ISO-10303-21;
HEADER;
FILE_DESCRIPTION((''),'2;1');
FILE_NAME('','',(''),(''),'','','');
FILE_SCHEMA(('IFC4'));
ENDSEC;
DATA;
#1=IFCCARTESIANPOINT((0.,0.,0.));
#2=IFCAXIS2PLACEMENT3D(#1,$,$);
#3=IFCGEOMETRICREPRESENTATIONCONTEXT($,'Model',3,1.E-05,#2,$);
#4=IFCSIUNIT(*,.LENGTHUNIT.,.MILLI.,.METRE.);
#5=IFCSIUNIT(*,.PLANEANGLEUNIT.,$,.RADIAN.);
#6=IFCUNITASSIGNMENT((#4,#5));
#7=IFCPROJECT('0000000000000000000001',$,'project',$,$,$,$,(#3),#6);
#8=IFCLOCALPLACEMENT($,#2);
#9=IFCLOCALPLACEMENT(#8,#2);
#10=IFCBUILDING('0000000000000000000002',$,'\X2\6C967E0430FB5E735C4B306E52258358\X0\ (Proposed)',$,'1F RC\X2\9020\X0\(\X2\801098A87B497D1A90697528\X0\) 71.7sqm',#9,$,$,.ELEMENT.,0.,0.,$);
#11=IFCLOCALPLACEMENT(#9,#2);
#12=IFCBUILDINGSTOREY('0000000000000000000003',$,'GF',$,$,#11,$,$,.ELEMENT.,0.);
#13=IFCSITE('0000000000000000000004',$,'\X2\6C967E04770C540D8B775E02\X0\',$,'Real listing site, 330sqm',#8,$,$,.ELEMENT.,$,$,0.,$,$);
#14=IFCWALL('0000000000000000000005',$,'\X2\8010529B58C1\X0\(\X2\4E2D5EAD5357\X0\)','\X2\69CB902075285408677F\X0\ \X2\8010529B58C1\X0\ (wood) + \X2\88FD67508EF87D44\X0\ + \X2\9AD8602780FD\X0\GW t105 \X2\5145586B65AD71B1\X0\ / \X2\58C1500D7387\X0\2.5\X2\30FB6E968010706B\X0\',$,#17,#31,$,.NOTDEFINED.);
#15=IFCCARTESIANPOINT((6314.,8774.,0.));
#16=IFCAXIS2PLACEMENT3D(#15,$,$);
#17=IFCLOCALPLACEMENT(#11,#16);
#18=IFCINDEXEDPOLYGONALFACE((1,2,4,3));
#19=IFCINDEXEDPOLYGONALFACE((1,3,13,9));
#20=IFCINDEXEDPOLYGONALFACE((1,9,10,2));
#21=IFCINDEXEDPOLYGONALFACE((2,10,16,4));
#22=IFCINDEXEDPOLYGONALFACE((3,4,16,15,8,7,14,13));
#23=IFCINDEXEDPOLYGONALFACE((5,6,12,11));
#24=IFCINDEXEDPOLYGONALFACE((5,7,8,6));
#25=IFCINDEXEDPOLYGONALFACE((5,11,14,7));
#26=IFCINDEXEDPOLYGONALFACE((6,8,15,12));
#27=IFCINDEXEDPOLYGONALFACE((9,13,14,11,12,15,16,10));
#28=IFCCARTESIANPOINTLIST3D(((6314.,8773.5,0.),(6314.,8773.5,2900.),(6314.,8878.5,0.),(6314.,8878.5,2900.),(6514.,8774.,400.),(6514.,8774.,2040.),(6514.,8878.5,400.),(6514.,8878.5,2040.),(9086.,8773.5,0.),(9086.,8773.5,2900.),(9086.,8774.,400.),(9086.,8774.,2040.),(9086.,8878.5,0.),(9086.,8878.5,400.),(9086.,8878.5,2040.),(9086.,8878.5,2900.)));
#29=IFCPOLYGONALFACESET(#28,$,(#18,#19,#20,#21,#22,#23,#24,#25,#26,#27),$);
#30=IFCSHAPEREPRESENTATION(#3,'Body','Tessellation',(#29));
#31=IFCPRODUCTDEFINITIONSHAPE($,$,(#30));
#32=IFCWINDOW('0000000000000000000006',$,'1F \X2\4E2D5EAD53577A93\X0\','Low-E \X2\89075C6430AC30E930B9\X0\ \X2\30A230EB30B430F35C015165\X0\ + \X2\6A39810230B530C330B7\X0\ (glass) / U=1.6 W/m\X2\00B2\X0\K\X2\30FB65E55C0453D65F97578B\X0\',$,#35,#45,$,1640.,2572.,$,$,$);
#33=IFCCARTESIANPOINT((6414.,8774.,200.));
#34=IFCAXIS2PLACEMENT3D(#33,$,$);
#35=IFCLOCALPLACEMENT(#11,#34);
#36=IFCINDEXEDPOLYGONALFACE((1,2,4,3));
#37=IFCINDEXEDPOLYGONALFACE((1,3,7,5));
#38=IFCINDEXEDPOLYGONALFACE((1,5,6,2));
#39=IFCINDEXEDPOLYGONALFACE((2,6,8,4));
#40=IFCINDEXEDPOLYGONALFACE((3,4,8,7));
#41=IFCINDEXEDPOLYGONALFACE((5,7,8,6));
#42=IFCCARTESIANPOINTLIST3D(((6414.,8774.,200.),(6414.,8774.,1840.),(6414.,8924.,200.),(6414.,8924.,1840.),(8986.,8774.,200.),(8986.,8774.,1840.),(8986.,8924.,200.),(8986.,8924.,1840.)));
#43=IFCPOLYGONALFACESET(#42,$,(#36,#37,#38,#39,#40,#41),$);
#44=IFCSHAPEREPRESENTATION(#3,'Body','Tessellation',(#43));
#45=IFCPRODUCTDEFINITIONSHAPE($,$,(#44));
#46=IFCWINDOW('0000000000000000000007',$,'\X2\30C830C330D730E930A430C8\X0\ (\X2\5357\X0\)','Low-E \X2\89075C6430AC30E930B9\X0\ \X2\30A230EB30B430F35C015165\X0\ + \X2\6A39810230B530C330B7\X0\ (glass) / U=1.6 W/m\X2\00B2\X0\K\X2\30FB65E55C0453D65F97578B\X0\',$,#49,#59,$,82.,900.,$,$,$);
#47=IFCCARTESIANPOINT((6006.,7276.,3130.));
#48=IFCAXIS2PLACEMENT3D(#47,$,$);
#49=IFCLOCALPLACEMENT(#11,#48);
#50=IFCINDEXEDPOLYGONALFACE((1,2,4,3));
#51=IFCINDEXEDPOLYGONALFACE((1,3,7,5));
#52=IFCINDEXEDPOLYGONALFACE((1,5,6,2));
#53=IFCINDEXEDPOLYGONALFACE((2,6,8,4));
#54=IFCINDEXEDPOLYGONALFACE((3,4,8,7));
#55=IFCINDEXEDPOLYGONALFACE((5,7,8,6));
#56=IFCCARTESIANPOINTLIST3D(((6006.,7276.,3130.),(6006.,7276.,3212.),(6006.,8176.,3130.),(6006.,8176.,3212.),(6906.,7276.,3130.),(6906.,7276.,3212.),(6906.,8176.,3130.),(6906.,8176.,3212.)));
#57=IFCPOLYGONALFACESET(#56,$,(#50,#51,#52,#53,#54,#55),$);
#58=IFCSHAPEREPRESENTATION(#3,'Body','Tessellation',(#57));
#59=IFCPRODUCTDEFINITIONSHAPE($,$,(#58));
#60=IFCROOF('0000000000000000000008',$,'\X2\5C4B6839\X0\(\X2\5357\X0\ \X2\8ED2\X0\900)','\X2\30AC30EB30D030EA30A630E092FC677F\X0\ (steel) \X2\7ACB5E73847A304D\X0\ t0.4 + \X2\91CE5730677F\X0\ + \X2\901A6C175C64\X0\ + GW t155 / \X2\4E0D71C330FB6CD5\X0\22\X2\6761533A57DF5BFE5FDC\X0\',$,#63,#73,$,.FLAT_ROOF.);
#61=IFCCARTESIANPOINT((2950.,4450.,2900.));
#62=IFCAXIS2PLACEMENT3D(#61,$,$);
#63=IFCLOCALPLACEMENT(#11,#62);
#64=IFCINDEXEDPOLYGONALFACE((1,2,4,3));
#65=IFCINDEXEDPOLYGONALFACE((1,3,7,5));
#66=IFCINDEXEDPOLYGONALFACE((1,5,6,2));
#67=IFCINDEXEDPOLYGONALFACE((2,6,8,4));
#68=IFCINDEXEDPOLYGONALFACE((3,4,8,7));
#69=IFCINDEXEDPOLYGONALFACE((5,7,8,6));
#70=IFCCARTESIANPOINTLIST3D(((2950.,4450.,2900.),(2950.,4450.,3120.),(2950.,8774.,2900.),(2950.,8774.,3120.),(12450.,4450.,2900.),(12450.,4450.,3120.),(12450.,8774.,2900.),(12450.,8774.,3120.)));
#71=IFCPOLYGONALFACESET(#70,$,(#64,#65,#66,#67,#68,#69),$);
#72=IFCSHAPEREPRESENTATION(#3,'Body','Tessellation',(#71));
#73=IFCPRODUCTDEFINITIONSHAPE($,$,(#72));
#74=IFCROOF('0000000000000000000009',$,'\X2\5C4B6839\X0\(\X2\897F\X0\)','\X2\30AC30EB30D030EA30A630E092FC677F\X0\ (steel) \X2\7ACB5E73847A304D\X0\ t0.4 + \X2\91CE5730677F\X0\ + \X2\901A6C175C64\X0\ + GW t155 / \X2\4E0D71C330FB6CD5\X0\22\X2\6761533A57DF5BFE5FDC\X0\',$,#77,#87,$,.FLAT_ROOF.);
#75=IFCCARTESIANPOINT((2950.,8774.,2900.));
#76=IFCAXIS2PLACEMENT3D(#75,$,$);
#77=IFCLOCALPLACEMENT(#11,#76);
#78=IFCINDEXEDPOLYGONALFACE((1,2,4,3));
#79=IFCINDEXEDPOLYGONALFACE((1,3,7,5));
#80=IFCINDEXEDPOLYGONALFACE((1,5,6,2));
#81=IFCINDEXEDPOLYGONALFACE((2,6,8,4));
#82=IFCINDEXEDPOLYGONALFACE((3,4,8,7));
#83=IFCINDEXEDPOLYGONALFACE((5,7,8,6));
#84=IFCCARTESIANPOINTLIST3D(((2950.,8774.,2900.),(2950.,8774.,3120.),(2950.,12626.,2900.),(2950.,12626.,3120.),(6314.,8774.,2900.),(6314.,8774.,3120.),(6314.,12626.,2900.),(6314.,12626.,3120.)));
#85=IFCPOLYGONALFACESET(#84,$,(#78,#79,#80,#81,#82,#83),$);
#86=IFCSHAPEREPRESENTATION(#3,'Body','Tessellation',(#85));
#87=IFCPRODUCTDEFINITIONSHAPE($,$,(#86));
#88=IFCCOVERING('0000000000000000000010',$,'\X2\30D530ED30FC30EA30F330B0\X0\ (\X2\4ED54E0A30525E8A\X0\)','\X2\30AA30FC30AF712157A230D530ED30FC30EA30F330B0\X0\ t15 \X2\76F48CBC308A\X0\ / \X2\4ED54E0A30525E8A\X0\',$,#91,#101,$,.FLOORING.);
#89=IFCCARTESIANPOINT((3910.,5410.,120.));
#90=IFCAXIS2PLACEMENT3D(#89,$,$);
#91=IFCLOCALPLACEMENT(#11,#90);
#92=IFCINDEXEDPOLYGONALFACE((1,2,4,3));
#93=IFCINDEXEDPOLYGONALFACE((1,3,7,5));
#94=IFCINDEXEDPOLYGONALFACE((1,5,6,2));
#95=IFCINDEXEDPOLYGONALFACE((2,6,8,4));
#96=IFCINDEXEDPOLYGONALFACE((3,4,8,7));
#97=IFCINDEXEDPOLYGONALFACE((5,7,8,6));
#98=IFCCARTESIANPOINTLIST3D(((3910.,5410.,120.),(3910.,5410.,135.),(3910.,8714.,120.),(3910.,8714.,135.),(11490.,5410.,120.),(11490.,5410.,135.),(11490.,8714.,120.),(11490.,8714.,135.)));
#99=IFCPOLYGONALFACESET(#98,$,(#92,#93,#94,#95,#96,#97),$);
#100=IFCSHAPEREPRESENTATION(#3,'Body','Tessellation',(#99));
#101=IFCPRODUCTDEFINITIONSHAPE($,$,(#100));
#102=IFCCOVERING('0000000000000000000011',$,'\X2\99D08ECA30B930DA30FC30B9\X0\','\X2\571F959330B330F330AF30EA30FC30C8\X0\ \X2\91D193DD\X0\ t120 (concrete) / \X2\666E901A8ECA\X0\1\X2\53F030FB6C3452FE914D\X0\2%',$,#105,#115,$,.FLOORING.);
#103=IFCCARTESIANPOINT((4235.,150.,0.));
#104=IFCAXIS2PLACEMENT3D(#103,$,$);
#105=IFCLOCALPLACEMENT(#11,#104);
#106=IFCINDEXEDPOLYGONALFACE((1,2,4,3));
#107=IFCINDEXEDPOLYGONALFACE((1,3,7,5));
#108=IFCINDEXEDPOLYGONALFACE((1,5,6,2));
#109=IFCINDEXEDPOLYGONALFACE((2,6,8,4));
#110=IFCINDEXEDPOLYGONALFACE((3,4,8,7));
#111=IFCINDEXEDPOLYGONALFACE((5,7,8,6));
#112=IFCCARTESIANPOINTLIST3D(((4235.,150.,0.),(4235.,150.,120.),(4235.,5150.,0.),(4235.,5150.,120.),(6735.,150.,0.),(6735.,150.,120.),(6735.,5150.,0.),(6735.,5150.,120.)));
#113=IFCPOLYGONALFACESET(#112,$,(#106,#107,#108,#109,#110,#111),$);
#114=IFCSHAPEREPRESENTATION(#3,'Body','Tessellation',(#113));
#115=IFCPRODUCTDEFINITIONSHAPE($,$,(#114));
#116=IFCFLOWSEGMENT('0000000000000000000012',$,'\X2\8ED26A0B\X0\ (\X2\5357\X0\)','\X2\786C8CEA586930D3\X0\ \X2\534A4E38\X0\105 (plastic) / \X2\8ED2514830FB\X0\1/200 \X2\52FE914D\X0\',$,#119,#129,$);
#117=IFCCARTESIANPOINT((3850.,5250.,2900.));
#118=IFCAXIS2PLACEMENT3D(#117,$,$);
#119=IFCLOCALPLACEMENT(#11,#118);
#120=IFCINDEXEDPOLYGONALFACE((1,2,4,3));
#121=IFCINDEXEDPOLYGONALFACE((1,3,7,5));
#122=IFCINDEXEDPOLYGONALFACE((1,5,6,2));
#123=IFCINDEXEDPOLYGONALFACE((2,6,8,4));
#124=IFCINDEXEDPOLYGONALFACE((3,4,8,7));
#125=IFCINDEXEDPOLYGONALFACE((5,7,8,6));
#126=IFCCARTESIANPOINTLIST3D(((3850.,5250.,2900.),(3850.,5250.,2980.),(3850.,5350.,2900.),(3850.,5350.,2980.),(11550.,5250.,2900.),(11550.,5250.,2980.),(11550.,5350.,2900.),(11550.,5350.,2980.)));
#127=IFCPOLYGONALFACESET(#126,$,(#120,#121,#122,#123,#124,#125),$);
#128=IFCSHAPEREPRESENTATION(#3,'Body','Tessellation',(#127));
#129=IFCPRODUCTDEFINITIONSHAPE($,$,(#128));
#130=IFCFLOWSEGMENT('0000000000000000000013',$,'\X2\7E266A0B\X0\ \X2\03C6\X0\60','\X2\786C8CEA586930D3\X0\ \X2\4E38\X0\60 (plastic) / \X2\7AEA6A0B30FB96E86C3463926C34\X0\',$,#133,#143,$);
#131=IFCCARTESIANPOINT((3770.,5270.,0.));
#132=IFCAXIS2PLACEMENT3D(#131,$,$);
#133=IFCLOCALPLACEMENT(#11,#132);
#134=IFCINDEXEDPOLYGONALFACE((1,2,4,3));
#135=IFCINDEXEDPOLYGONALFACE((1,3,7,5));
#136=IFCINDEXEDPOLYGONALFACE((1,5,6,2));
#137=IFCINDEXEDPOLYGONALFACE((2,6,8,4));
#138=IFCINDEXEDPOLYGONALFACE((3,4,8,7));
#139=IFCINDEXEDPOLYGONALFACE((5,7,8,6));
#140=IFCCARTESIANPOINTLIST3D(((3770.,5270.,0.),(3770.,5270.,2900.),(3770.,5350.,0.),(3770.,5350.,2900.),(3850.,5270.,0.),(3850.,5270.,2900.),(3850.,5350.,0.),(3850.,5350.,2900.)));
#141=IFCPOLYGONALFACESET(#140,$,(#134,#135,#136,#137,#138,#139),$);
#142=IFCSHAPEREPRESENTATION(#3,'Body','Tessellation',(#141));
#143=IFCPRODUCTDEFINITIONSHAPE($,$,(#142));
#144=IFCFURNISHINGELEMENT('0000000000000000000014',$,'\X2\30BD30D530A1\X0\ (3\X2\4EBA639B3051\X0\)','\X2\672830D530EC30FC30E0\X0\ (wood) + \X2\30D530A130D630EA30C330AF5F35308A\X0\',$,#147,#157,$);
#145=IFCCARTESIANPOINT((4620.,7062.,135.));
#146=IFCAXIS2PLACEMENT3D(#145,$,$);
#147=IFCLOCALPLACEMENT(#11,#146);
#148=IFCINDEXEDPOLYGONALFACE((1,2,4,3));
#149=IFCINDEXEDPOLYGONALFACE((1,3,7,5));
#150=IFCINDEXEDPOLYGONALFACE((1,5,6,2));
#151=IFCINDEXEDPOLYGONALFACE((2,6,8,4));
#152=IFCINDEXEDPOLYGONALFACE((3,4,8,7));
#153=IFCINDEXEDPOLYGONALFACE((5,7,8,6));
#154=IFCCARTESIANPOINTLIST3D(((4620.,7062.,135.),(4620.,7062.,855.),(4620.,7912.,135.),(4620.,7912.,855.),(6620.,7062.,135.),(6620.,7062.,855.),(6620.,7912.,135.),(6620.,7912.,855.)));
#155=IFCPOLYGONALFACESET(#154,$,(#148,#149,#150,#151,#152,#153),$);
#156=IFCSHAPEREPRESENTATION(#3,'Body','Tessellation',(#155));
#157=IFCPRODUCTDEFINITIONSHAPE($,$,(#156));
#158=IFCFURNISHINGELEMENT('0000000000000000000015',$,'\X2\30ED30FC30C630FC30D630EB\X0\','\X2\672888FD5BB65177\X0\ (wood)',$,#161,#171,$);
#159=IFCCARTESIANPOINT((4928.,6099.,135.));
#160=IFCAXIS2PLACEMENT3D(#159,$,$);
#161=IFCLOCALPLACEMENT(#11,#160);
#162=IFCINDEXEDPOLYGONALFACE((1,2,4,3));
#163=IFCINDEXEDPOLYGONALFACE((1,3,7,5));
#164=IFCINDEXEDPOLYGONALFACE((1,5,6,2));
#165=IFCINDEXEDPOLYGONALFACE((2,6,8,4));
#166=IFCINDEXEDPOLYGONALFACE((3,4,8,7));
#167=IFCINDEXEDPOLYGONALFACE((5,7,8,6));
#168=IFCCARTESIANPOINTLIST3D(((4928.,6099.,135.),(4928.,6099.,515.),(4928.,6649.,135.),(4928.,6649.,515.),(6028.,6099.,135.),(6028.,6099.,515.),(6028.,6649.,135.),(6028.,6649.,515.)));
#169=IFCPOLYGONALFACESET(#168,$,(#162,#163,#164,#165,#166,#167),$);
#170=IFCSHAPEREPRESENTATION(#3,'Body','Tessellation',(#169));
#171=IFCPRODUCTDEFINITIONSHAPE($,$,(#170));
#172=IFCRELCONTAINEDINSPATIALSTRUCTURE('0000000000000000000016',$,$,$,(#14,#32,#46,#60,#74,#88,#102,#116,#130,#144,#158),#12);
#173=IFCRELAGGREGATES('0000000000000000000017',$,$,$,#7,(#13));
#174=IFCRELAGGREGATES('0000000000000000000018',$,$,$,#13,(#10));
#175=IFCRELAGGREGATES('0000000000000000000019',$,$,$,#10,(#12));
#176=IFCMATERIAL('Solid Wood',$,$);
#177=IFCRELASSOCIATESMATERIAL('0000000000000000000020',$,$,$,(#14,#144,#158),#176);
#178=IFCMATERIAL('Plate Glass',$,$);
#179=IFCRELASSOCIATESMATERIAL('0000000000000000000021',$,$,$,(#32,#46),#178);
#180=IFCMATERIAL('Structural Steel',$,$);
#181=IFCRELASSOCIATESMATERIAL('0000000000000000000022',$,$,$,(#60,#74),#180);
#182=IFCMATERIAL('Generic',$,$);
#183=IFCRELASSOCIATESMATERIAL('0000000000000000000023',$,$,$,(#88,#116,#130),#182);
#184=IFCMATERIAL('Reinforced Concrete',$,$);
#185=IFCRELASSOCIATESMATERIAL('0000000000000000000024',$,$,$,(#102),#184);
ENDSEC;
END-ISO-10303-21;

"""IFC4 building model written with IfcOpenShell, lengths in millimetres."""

from ifc_helpers import new_model, si_unit, frame, frame_2d, origin, place, context, project, spatial, rectangle, extrude, material, element, fill, save


model = new_model("IFC4")

# Units and contexts
model_context = context("Model", 3, precision=1e-05, world=origin())
ifc_project = project(units=[si_unit("LENGTHUNIT", "METRE", prefix="MILLI"), si_unit("PLANEANGLEUNIT", "RADIAN")], contexts=[model_context])

# Site, building, storey
site_placement = place(None, origin())
site = spatial("IfcSite", under=ifc_project, at=site_placement, Name="沖縄県名護市", ObjectType="Real listing site, 330sqm", CompositionType="ELEMENT", RefElevation=0.0)
building_placement = place(site_placement, origin())
building = spatial("IfcBuilding", under=site, at=building_placement, Name="沖縄・平屋の別荘 (Proposed)", ObjectType="1F RC造(耐風等級適用) 71.7sqm", CompositionType="ELEMENT", ElevationOfRefHeight=0.0, ElevationOfTerrain=0.0)
storey_placement = place(building_placement, origin())
storey = spatial("IfcBuildingStorey", under=building, at=storey_placement, Name="GF", CompositionType="ELEMENT", Elevation=0.0)

# Shared definitions
ifc_material_1 = material(Name="Solid Wood")

# Shared definitions
ifc_material_2 = material(Name="Reinforced Concrete")

# Shared definitions
ifc_material_3 = material(Name="Plate Glass")

# Wall, opening, window
wall_1_placement = place(storey_placement, frame((6314.0, 8774.0, 0.0)))
wall_1 = element("IfcWall", 1, at=wall_1_placement, inside=storey, material=ifc_material_1, Name="耐力壁(中庭南)", Description="構造用合板 耐力壁 (wood) + 製材軸組 + 高性能GW t105 充填断熱 / 壁倍率2.5・準耐火", PredefinedType="NOTDEFINED", context=model_context, shape_type="SweptSolid", body=[
    extrude(rectangle(XDim=2772.0, YDim=105.0, at=frame_2d((1386.0, 52.0))), frame((6314.0, 8774.0, 0.0)), (0.0, 0.0, 1.0), 2900.0),
])
opening_1_placement = place(storey_placement, frame((6414.0, 8774.0, 200.0)))
opening_1 = element("IfcOpeningElement", 2, at=opening_1_placement, cuts=wall_1, PredefinedType="NOTDEFINED", context=model_context, shape_type="SweptSolid", body=[
    extrude(rectangle(XDim=2572.0, YDim=150.0, at=frame_2d((1286.0, 75.0))), frame((6414.0, 8774.0, 200.0)), (0.0, 0.0, 1.0), 1640.0),
])
window_1_placement = place(storey_placement, frame((6414.0, 8774.0, 200.0)))
window_1 = element("IfcWindow", 3, at=window_1_placement, inside=storey, material=ifc_material_3, Name="1F 中庭南窓", Description="Low-E 複層ガラス アルゴン封入 + 樹脂サッシ (glass) / U=1.6 W/m²K・日射取得型", OverallHeight=1640.0, OverallWidth=2572.0, context=model_context, shape_type="SweptSolid", body=[
    extrude(rectangle(XDim=2572.0, YDim=150.0, at=frame_2d((1286.0, 75.0))), frame((6414.0, 8774.0, 200.0)), (0.0, 0.0, 1.0), 1640.0),
])
fill(opening_1, window_1)

# Window
window_2_placement = place(storey_placement, frame((6006.0, 7276.0, 3130.0)))
element("IfcWindow", 4, at=window_2_placement, inside=storey, material=ifc_material_3, Name="トップライト (南)", Description="Low-E 複層ガラス アルゴン封入 + 樹脂サッシ (glass) / U=1.6 W/m²K・日射取得型", OverallHeight=82.0, OverallWidth=900.0, context=model_context, shape_type="SweptSolid", body=[
    extrude(rectangle(XDim=900.0, YDim=900.0, at=frame_2d((450.0, 450.0))), frame((6006.0, 7276.0, 3130.0)), (0.0, 0.0, 1.0), 82.0),
])

# Roofs
ifc_material_4 = material(Name="Structural Steel")
roof_1_placement = place(storey_placement, frame((2950.0, 4450.0, 2900.0)))
element("IfcRoof", 5, at=roof_1_placement, inside=storey, material=ifc_material_4, Name="屋根(南 軒900)", Description="ガルバリウム鋼板 (steel) 立平葺き t0.4 + 野地板 + 通気層 + GW t155 / 不燃・法22条区域対応", PredefinedType="FLAT_ROOF", context=model_context, shape_type="SweptSolid", body=[
    extrude(rectangle(XDim=9500.0, YDim=4324.0, at=frame_2d((4750.0, 2162.0))), frame((2950.0, 4450.0, 2900.0)), (0.0, 0.0, 1.0), 220.0),
])
roof_2_placement = place(storey_placement, frame((2950.0, 8774.0, 2900.0)))
element("IfcRoof", 6, at=roof_2_placement, inside=storey, material=ifc_material_4, Name="屋根(西)", Description="ガルバリウム鋼板 (steel) 立平葺き t0.4 + 野地板 + 通気層 + GW t155 / 不燃・法22条区域対応", PredefinedType="FLAT_ROOF", context=model_context, shape_type="SweptSolid", body=[
    extrude(rectangle(XDim=3364.0, YDim=3852.0, at=frame_2d((1682.0, 1926.0))), frame((2950.0, 8774.0, 2900.0)), (0.0, 0.0, 1.0), 220.0),
])

# Coverings
ifc_material_5 = material(Name="Generic")
covering_1_placement = place(storey_placement, frame((3910.0, 5410.0, 120.0)))
element("IfcCovering", 7, at=covering_1_placement, inside=storey, material=ifc_material_5, Name="フローリング (仕上げ床)", Description="オーク無垢フローリング t15 直貼り / 仕上げ床", PredefinedType="FLOORING", context=model_context, shape_type="SweptSolid", body=[
    extrude(rectangle(XDim=7580.0, YDim=3304.0, at=frame_2d((3790.0, 1652.0))), frame((3910.0, 5410.0, 120.0)), (0.0, 0.0, 1.0), 15.0),
])
covering_2_placement = place(storey_placement, frame((4235.0, 150.0, 0.0)))
element("IfcCovering", 8, at=covering_2_placement, inside=storey, material=ifc_material_2, Name="駐車スペース", Description="土間コンクリート 金鏝 t120 (concrete) / 普通車1台・水勾配2%", PredefinedType="FLOORING", context=model_context, shape_type="SweptSolid", body=[
    extrude(rectangle(XDim=2500.0, YDim=5000.0, at=frame_2d((1250.0, 2500.0))), frame((4235.0, 150.0, 0.0)), (0.0, 0.0, 1.0), 120.0),
])

# Flow segments
flow_segment_1_placement = place(storey_placement, frame((3850.0, 5250.0, 2900.0)))
element("IfcFlowSegment", 9, at=flow_segment_1_placement, inside=storey, material=ifc_material_5, Name="軒樋 (南)", Description="硬質塩ビ 半丸105 (plastic) / 軒先・1/200 勾配", context=model_context, shape_type="SweptSolid", body=[
    extrude(rectangle(XDim=7700.0, YDim=100.0, at=frame_2d((3850.0, 50.0))), frame((3850.0, 5250.0, 2900.0)), (0.0, 0.0, 1.0), 80.0),
])
flow_segment_2_placement = place(storey_placement, frame((3770.0, 5270.0, 0.0)))
element("IfcFlowSegment", 10, at=flow_segment_2_placement, inside=storey, material=ifc_material_5, Name="縦樋 φ60", Description="硬質塩ビ 丸60 (plastic) / 竪樋・雨水排水", context=model_context, shape_type="SweptSolid", body=[
    extrude(rectangle(XDim=80.0, YDim=80.0, at=frame_2d((40.0, 40.0))), frame((3770.0, 5270.0, 0.0)), (0.0, 0.0, 1.0), 2900.0),
])

# Furnishing elements
furnishing_1_placement = place(storey_placement, frame((4620.0, 7062.0, 135.0)))
element("IfcFurnishingElement", 11, at=furnishing_1_placement, inside=storey, material=ifc_material_1, Name="ソファ (3人掛け)", Description="木フレーム (wood) + ファブリック張り", context=model_context, shape_type="SweptSolid", body=[
    extrude(rectangle(XDim=2000.0, YDim=850.0, at=frame_2d((1000.0, 425.0))), frame((4620.0, 7062.0, 135.0)), (0.0, 0.0, 1.0), 720.0),
])
furnishing_2_placement = place(storey_placement, frame((4928.0, 6099.0, 135.0)))
element("IfcFurnishingElement", 12, at=furnishing_2_placement, inside=storey, material=ifc_material_1, Name="ローテーブル", Description="木製家具 (wood)", context=model_context, shape_type="SweptSolid", body=[
    extrude(rectangle(XDim=1100.0, YDim=550.0, at=frame_2d((550.0, 275.0))), frame((4928.0, 6099.0, 135.0)), (0.0, 0.0, 1.0), 380.0),
])

save(model, "model.ifc")
